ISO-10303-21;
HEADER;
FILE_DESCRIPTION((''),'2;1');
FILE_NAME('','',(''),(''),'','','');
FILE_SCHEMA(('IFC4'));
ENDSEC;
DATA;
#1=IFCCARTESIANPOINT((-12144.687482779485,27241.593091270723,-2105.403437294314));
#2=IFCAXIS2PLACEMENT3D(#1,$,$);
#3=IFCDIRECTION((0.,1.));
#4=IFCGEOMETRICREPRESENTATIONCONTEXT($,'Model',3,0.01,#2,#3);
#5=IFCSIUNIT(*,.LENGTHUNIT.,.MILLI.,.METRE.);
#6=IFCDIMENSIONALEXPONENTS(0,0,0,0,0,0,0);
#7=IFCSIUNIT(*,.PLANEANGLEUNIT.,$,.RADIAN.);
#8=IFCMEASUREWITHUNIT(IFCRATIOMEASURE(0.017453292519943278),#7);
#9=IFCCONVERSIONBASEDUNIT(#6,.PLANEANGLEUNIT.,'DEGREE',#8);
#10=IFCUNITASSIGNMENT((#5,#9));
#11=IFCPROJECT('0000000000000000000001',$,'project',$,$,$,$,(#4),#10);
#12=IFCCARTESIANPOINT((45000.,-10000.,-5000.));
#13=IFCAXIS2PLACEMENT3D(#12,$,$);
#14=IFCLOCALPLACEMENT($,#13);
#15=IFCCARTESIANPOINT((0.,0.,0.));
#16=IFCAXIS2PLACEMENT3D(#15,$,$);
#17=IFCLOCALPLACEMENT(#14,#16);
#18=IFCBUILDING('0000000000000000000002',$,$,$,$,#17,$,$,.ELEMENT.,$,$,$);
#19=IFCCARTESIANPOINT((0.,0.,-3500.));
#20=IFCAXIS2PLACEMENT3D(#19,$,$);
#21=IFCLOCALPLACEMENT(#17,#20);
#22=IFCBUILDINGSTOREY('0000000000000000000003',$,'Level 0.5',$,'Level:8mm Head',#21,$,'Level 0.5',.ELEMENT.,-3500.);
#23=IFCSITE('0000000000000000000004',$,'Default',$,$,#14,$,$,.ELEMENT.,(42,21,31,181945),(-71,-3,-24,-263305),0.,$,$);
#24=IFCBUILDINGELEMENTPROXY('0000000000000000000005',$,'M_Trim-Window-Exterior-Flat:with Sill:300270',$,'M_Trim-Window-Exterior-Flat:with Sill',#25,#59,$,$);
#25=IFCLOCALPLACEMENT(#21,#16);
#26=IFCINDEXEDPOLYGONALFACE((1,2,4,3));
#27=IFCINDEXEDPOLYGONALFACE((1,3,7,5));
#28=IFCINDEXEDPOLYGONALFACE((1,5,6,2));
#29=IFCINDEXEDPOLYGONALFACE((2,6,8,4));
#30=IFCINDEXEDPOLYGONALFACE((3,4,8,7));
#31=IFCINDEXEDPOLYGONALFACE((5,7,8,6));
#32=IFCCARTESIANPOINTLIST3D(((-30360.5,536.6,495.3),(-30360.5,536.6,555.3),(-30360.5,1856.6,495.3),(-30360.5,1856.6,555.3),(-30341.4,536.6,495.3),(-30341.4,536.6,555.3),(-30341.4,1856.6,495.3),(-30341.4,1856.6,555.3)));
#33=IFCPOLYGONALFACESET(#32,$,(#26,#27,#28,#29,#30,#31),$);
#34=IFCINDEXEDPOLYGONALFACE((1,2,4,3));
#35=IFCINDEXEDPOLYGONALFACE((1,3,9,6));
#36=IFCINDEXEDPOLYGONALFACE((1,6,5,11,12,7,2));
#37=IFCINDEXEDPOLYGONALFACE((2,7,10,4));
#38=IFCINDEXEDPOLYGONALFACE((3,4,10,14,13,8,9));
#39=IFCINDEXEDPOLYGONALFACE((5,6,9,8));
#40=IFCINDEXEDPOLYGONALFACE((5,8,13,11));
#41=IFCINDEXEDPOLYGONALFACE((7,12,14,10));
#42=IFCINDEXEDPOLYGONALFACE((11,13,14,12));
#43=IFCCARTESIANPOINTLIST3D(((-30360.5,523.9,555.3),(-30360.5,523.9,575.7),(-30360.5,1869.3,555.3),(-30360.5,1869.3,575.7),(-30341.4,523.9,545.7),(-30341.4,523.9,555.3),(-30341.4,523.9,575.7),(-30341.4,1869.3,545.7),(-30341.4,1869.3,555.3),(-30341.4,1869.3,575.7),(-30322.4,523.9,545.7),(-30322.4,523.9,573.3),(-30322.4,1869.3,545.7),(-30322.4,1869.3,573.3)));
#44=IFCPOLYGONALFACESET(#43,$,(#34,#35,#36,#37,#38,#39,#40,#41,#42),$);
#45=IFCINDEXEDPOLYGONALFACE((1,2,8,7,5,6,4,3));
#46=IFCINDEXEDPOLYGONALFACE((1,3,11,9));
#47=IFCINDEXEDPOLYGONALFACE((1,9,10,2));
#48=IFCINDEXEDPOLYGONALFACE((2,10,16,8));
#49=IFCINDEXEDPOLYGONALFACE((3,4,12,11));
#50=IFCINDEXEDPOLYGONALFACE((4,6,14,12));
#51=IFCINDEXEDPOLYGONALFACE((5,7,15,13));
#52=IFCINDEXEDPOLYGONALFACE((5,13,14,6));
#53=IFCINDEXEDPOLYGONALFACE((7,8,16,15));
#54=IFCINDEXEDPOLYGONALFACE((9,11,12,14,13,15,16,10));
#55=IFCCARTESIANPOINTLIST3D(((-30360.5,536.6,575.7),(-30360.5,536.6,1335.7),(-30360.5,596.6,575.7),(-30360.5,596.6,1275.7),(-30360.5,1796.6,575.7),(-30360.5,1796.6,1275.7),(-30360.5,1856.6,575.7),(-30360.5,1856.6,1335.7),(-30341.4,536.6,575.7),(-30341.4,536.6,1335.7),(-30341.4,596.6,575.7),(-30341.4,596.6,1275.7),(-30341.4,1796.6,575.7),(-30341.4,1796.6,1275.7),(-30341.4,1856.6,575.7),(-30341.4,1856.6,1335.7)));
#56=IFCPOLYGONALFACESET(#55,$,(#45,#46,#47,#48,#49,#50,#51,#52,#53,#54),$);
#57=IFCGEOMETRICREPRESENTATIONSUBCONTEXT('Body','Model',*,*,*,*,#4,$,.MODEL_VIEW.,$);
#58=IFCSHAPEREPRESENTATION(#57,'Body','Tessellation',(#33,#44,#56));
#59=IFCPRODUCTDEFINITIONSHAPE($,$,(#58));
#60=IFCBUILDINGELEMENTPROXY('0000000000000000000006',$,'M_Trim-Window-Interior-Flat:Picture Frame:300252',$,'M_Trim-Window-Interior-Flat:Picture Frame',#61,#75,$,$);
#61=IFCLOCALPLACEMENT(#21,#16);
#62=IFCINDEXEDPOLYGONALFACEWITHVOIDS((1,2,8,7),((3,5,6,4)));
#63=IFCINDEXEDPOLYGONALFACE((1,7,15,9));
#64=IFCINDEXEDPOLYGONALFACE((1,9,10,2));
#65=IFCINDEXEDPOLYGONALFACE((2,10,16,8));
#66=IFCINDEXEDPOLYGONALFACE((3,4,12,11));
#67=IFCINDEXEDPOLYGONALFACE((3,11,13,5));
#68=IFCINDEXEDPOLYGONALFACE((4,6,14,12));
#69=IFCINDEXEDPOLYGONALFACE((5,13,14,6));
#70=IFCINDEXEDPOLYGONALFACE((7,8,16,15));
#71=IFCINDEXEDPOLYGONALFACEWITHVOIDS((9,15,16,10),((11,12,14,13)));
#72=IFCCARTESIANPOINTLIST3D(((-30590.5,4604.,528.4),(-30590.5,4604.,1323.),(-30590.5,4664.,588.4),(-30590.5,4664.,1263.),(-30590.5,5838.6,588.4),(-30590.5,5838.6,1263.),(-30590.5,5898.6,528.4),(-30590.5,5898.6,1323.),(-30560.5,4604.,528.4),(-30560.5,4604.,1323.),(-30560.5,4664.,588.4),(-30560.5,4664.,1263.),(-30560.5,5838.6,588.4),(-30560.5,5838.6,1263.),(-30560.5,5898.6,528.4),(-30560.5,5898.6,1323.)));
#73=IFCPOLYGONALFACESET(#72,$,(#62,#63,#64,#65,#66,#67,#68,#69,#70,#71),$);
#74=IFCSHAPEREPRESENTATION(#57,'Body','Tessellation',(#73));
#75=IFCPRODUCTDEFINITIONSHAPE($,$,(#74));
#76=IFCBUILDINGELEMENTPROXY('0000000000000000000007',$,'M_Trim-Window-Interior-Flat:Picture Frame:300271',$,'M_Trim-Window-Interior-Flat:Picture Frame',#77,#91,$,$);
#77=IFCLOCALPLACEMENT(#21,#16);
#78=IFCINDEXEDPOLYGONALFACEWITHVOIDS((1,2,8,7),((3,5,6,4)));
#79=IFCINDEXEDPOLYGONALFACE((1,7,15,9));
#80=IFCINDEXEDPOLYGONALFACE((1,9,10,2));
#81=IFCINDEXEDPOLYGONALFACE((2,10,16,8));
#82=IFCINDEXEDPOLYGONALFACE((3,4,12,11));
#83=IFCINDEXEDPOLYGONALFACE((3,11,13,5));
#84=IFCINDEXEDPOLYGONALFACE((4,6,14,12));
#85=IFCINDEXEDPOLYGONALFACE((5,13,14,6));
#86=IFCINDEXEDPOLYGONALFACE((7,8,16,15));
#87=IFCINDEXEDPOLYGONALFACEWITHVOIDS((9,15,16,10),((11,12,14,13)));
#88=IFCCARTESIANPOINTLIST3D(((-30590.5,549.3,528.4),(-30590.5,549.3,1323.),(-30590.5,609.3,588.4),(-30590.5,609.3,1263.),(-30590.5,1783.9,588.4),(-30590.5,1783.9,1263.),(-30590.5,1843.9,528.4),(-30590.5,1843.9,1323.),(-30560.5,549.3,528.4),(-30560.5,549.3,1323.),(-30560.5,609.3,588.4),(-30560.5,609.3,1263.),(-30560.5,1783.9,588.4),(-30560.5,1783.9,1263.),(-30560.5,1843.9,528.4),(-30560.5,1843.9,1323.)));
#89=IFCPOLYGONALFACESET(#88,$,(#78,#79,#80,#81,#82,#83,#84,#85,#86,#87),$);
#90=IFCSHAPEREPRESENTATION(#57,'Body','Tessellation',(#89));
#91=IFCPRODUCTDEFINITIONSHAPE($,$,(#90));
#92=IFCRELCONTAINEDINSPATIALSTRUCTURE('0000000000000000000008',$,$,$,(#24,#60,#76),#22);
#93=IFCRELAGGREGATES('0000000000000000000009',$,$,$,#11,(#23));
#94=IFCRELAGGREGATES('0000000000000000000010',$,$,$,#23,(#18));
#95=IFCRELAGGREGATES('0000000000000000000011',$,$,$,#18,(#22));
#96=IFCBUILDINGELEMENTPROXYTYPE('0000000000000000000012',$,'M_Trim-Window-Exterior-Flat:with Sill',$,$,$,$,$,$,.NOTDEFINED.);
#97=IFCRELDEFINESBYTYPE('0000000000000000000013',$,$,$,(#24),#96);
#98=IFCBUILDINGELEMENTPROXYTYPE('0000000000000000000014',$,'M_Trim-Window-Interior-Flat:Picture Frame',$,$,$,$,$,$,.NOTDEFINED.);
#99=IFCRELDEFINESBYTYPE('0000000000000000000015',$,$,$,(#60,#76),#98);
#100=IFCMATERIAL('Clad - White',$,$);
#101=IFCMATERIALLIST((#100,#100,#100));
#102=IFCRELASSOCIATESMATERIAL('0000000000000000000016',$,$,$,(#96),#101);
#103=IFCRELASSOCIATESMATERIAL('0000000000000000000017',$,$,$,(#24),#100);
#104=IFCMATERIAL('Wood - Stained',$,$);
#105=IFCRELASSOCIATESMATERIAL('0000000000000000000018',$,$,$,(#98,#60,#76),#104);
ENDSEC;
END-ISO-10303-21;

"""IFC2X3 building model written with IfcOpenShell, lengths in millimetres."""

from ifc_helpers import new_model, entity, si_unit, converted_unit, direction, frame, frame_2d, origin, place, context, subcontext, project, spatial, polyline, rectangle, outline, extrude, source, transform, mapped, material, material_list, type_object, type_shapes, element, save


model = new_model("IFC2X3")

# Units and contexts
model_context = context("Model", 3, precision=0.01, world=frame((-12144.687482779485, 27241.593091270723, -2105.403437294314)), true_north=direction((0.0, 1.0)))
body_context = subcontext(model_context, "Body", "Model", "MODEL_VIEW")
ifc_project = project(units=[si_unit("LENGTHUNIT", "METRE", prefix="MILLI"), converted_unit("PLANEANGLEUNIT", "DEGREE", entity("IfcRatioMeasure", 0.017453292519943278), si_unit("PLANEANGLEUNIT", "RADIAN"), dimensions=[0, 0, 0, 0, 0, 0, 0])], contexts=[model_context])

# Site, building, storey
site_placement = place(None, frame((45000.0, -10000.0, -5000.0)))
site = spatial("IfcSite", under=ifc_project, at=site_placement, Name="Default", CompositionType="ELEMENT", RefLatitude=(42, 21, 31, 181945), RefLongitude=(-71, -3, -24, -263305), RefElevation=0.0)
building_placement = place(site_placement, origin())
building = spatial("IfcBuilding", under=site, at=building_placement, CompositionType="ELEMENT")
storey_placement = place(building_placement, frame((0.0, 0.0, -3500.0)))
storey = spatial("IfcBuildingStorey", under=building, at=storey_placement, Name="Level 0.5", ObjectType="Level:8mm Head", LongName="Level 0.5", CompositionType="ELEMENT", Elevation=-3500.0)

# Building element proxies
ifc_material_1 = material(Name="Clad - White")
ifc_material_2 = material(Name="Wood - Stained")
ifc_material_list_1 = material_list([ifc_material_1, ifc_material_1, ifc_material_1])
building_element_proxy_type_1 = type_object("IfcBuildingElementProxyType", Name="M_Trim-Window-Exterior-Flat:with Sill", PredefinedType="NOTDEFINED", material=ifc_material_list_1)
shared_shape_1 = source(origin(), body_context, "Body", "SweptSolid", [
    extrude(rectangle(XDim=1320.0, YDim=60.0, at=frame_2d((0.0, 0.0), x_axis=(1.0, 0.0))), frame((0.0, -750.4, 0.0), z_axis=(0.0, 0.0, 1.0), x_axis=(-1.0, 0.0, 0.0)), (0.0, 0.0, 1.0), 19.0),
    extrude(outline(polyline([(-19.0, -15.2), (0.0, -15.2), (0.0, -5.7), (19.0, -5.7), (19.0, 14.8), (0.0, 14.8), (-19.0, 12.3), (-19.0, -15.2)])), frame((-672.7, -714.8, 19.0), z_axis=(1.0, 0.0, 0.0), x_axis=(0.0, 0.0, -1.0)), (0.0, 0.0, 1.0), 1345.4),
    extrude(outline(polyline([(-395.0, -660.0), (365.0, -660.0), (365.0, -600.0), (-335.0, -600.0), (-335.0, 600.0), (365.0, 600.0), (365.0, 660.0), (-395.0, 660.0), (-395.0, -660.0)])), frame((0.0, -335.0, 0.0), z_axis=(0.0, 0.0, 1.0), x_axis=(0.0, -1.0, 0.0)), (0.0, 0.0, 1.0), 19.0),
])
type_shapes(building_element_proxy_type_1, [shared_shape_1])
for number, where, z_axis, x_axis, name in (
    (1, (-30360.5, 1196.6, 1275.7), (1.0, 0.0, 0.0), (0.0, 1.0, 0.0), "M_Trim-Window-Exterior-Flat:with Sill:300270"),
):
    element("IfcBuildingElementProxy", number, at=place(storey_placement, frame(where, z_axis=z_axis, x_axis=x_axis)), inside=storey, type_object=building_element_proxy_type_1, material=ifc_material_1, Name=name, ObjectType="M_Trim-Window-Exterior-Flat:with Sill", context=body_context, shape_type="MappedRepresentation", body=[
        mapped(shared_shape_1, transform((0.0, 0.0, 0.0), scale=1.0)),
    ])
building_element_proxy_type_2 = type_object("IfcBuildingElementProxyType", Name="M_Trim-Window-Interior-Flat:Picture Frame", PredefinedType="NOTDEFINED", material=ifc_material_2)
shared_shape_2 = source(origin(), body_context, "Body", "SweptSolid", [
    extrude(outline(polyline([(-647.3, -397.3), (647.3, -397.3), (647.3, 397.3), (-647.3, 397.3), (-647.3, -397.3)]), holes=[polyline([(-587.3, -337.3), (-587.3, 337.3), (587.3, 337.3), (587.3, -337.3), (-587.3, -337.3)])]), frame((0.0, -350.0, 0.0), z_axis=(0.0, 0.0, 1.0), x_axis=(-1.0, 0.0, 0.0)), (0.0, 0.0, 1.0), 30.0),
])
type_shapes(building_element_proxy_type_2, [shared_shape_2])
for number, where, z_axis, x_axis, name in (
    (2, (-30560.5, 5251.3, 1275.7), (-1.0, 0.0, 0.0), (0.0, -1.0, 0.0), "M_Trim-Window-Interior-Flat:Picture Frame:300252"),
    (3, (-30560.5, 1196.6, 1275.7), (-1.0, 0.0, 0.0), (0.0, -1.0, 0.0), "M_Trim-Window-Interior-Flat:Picture Frame:300271"),
):
    element("IfcBuildingElementProxy", number, at=place(storey_placement, frame(where, z_axis=z_axis, x_axis=x_axis)), inside=storey, type_object=building_element_proxy_type_2, material=ifc_material_2, Name=name, ObjectType="M_Trim-Window-Interior-Flat:Picture Frame", context=body_context, shape_type="MappedRepresentation", body=[
        mapped(shared_shape_2, transform((0.0, 0.0, 0.0), scale=1.0)),
    ])

save(model, "model.ifc")
